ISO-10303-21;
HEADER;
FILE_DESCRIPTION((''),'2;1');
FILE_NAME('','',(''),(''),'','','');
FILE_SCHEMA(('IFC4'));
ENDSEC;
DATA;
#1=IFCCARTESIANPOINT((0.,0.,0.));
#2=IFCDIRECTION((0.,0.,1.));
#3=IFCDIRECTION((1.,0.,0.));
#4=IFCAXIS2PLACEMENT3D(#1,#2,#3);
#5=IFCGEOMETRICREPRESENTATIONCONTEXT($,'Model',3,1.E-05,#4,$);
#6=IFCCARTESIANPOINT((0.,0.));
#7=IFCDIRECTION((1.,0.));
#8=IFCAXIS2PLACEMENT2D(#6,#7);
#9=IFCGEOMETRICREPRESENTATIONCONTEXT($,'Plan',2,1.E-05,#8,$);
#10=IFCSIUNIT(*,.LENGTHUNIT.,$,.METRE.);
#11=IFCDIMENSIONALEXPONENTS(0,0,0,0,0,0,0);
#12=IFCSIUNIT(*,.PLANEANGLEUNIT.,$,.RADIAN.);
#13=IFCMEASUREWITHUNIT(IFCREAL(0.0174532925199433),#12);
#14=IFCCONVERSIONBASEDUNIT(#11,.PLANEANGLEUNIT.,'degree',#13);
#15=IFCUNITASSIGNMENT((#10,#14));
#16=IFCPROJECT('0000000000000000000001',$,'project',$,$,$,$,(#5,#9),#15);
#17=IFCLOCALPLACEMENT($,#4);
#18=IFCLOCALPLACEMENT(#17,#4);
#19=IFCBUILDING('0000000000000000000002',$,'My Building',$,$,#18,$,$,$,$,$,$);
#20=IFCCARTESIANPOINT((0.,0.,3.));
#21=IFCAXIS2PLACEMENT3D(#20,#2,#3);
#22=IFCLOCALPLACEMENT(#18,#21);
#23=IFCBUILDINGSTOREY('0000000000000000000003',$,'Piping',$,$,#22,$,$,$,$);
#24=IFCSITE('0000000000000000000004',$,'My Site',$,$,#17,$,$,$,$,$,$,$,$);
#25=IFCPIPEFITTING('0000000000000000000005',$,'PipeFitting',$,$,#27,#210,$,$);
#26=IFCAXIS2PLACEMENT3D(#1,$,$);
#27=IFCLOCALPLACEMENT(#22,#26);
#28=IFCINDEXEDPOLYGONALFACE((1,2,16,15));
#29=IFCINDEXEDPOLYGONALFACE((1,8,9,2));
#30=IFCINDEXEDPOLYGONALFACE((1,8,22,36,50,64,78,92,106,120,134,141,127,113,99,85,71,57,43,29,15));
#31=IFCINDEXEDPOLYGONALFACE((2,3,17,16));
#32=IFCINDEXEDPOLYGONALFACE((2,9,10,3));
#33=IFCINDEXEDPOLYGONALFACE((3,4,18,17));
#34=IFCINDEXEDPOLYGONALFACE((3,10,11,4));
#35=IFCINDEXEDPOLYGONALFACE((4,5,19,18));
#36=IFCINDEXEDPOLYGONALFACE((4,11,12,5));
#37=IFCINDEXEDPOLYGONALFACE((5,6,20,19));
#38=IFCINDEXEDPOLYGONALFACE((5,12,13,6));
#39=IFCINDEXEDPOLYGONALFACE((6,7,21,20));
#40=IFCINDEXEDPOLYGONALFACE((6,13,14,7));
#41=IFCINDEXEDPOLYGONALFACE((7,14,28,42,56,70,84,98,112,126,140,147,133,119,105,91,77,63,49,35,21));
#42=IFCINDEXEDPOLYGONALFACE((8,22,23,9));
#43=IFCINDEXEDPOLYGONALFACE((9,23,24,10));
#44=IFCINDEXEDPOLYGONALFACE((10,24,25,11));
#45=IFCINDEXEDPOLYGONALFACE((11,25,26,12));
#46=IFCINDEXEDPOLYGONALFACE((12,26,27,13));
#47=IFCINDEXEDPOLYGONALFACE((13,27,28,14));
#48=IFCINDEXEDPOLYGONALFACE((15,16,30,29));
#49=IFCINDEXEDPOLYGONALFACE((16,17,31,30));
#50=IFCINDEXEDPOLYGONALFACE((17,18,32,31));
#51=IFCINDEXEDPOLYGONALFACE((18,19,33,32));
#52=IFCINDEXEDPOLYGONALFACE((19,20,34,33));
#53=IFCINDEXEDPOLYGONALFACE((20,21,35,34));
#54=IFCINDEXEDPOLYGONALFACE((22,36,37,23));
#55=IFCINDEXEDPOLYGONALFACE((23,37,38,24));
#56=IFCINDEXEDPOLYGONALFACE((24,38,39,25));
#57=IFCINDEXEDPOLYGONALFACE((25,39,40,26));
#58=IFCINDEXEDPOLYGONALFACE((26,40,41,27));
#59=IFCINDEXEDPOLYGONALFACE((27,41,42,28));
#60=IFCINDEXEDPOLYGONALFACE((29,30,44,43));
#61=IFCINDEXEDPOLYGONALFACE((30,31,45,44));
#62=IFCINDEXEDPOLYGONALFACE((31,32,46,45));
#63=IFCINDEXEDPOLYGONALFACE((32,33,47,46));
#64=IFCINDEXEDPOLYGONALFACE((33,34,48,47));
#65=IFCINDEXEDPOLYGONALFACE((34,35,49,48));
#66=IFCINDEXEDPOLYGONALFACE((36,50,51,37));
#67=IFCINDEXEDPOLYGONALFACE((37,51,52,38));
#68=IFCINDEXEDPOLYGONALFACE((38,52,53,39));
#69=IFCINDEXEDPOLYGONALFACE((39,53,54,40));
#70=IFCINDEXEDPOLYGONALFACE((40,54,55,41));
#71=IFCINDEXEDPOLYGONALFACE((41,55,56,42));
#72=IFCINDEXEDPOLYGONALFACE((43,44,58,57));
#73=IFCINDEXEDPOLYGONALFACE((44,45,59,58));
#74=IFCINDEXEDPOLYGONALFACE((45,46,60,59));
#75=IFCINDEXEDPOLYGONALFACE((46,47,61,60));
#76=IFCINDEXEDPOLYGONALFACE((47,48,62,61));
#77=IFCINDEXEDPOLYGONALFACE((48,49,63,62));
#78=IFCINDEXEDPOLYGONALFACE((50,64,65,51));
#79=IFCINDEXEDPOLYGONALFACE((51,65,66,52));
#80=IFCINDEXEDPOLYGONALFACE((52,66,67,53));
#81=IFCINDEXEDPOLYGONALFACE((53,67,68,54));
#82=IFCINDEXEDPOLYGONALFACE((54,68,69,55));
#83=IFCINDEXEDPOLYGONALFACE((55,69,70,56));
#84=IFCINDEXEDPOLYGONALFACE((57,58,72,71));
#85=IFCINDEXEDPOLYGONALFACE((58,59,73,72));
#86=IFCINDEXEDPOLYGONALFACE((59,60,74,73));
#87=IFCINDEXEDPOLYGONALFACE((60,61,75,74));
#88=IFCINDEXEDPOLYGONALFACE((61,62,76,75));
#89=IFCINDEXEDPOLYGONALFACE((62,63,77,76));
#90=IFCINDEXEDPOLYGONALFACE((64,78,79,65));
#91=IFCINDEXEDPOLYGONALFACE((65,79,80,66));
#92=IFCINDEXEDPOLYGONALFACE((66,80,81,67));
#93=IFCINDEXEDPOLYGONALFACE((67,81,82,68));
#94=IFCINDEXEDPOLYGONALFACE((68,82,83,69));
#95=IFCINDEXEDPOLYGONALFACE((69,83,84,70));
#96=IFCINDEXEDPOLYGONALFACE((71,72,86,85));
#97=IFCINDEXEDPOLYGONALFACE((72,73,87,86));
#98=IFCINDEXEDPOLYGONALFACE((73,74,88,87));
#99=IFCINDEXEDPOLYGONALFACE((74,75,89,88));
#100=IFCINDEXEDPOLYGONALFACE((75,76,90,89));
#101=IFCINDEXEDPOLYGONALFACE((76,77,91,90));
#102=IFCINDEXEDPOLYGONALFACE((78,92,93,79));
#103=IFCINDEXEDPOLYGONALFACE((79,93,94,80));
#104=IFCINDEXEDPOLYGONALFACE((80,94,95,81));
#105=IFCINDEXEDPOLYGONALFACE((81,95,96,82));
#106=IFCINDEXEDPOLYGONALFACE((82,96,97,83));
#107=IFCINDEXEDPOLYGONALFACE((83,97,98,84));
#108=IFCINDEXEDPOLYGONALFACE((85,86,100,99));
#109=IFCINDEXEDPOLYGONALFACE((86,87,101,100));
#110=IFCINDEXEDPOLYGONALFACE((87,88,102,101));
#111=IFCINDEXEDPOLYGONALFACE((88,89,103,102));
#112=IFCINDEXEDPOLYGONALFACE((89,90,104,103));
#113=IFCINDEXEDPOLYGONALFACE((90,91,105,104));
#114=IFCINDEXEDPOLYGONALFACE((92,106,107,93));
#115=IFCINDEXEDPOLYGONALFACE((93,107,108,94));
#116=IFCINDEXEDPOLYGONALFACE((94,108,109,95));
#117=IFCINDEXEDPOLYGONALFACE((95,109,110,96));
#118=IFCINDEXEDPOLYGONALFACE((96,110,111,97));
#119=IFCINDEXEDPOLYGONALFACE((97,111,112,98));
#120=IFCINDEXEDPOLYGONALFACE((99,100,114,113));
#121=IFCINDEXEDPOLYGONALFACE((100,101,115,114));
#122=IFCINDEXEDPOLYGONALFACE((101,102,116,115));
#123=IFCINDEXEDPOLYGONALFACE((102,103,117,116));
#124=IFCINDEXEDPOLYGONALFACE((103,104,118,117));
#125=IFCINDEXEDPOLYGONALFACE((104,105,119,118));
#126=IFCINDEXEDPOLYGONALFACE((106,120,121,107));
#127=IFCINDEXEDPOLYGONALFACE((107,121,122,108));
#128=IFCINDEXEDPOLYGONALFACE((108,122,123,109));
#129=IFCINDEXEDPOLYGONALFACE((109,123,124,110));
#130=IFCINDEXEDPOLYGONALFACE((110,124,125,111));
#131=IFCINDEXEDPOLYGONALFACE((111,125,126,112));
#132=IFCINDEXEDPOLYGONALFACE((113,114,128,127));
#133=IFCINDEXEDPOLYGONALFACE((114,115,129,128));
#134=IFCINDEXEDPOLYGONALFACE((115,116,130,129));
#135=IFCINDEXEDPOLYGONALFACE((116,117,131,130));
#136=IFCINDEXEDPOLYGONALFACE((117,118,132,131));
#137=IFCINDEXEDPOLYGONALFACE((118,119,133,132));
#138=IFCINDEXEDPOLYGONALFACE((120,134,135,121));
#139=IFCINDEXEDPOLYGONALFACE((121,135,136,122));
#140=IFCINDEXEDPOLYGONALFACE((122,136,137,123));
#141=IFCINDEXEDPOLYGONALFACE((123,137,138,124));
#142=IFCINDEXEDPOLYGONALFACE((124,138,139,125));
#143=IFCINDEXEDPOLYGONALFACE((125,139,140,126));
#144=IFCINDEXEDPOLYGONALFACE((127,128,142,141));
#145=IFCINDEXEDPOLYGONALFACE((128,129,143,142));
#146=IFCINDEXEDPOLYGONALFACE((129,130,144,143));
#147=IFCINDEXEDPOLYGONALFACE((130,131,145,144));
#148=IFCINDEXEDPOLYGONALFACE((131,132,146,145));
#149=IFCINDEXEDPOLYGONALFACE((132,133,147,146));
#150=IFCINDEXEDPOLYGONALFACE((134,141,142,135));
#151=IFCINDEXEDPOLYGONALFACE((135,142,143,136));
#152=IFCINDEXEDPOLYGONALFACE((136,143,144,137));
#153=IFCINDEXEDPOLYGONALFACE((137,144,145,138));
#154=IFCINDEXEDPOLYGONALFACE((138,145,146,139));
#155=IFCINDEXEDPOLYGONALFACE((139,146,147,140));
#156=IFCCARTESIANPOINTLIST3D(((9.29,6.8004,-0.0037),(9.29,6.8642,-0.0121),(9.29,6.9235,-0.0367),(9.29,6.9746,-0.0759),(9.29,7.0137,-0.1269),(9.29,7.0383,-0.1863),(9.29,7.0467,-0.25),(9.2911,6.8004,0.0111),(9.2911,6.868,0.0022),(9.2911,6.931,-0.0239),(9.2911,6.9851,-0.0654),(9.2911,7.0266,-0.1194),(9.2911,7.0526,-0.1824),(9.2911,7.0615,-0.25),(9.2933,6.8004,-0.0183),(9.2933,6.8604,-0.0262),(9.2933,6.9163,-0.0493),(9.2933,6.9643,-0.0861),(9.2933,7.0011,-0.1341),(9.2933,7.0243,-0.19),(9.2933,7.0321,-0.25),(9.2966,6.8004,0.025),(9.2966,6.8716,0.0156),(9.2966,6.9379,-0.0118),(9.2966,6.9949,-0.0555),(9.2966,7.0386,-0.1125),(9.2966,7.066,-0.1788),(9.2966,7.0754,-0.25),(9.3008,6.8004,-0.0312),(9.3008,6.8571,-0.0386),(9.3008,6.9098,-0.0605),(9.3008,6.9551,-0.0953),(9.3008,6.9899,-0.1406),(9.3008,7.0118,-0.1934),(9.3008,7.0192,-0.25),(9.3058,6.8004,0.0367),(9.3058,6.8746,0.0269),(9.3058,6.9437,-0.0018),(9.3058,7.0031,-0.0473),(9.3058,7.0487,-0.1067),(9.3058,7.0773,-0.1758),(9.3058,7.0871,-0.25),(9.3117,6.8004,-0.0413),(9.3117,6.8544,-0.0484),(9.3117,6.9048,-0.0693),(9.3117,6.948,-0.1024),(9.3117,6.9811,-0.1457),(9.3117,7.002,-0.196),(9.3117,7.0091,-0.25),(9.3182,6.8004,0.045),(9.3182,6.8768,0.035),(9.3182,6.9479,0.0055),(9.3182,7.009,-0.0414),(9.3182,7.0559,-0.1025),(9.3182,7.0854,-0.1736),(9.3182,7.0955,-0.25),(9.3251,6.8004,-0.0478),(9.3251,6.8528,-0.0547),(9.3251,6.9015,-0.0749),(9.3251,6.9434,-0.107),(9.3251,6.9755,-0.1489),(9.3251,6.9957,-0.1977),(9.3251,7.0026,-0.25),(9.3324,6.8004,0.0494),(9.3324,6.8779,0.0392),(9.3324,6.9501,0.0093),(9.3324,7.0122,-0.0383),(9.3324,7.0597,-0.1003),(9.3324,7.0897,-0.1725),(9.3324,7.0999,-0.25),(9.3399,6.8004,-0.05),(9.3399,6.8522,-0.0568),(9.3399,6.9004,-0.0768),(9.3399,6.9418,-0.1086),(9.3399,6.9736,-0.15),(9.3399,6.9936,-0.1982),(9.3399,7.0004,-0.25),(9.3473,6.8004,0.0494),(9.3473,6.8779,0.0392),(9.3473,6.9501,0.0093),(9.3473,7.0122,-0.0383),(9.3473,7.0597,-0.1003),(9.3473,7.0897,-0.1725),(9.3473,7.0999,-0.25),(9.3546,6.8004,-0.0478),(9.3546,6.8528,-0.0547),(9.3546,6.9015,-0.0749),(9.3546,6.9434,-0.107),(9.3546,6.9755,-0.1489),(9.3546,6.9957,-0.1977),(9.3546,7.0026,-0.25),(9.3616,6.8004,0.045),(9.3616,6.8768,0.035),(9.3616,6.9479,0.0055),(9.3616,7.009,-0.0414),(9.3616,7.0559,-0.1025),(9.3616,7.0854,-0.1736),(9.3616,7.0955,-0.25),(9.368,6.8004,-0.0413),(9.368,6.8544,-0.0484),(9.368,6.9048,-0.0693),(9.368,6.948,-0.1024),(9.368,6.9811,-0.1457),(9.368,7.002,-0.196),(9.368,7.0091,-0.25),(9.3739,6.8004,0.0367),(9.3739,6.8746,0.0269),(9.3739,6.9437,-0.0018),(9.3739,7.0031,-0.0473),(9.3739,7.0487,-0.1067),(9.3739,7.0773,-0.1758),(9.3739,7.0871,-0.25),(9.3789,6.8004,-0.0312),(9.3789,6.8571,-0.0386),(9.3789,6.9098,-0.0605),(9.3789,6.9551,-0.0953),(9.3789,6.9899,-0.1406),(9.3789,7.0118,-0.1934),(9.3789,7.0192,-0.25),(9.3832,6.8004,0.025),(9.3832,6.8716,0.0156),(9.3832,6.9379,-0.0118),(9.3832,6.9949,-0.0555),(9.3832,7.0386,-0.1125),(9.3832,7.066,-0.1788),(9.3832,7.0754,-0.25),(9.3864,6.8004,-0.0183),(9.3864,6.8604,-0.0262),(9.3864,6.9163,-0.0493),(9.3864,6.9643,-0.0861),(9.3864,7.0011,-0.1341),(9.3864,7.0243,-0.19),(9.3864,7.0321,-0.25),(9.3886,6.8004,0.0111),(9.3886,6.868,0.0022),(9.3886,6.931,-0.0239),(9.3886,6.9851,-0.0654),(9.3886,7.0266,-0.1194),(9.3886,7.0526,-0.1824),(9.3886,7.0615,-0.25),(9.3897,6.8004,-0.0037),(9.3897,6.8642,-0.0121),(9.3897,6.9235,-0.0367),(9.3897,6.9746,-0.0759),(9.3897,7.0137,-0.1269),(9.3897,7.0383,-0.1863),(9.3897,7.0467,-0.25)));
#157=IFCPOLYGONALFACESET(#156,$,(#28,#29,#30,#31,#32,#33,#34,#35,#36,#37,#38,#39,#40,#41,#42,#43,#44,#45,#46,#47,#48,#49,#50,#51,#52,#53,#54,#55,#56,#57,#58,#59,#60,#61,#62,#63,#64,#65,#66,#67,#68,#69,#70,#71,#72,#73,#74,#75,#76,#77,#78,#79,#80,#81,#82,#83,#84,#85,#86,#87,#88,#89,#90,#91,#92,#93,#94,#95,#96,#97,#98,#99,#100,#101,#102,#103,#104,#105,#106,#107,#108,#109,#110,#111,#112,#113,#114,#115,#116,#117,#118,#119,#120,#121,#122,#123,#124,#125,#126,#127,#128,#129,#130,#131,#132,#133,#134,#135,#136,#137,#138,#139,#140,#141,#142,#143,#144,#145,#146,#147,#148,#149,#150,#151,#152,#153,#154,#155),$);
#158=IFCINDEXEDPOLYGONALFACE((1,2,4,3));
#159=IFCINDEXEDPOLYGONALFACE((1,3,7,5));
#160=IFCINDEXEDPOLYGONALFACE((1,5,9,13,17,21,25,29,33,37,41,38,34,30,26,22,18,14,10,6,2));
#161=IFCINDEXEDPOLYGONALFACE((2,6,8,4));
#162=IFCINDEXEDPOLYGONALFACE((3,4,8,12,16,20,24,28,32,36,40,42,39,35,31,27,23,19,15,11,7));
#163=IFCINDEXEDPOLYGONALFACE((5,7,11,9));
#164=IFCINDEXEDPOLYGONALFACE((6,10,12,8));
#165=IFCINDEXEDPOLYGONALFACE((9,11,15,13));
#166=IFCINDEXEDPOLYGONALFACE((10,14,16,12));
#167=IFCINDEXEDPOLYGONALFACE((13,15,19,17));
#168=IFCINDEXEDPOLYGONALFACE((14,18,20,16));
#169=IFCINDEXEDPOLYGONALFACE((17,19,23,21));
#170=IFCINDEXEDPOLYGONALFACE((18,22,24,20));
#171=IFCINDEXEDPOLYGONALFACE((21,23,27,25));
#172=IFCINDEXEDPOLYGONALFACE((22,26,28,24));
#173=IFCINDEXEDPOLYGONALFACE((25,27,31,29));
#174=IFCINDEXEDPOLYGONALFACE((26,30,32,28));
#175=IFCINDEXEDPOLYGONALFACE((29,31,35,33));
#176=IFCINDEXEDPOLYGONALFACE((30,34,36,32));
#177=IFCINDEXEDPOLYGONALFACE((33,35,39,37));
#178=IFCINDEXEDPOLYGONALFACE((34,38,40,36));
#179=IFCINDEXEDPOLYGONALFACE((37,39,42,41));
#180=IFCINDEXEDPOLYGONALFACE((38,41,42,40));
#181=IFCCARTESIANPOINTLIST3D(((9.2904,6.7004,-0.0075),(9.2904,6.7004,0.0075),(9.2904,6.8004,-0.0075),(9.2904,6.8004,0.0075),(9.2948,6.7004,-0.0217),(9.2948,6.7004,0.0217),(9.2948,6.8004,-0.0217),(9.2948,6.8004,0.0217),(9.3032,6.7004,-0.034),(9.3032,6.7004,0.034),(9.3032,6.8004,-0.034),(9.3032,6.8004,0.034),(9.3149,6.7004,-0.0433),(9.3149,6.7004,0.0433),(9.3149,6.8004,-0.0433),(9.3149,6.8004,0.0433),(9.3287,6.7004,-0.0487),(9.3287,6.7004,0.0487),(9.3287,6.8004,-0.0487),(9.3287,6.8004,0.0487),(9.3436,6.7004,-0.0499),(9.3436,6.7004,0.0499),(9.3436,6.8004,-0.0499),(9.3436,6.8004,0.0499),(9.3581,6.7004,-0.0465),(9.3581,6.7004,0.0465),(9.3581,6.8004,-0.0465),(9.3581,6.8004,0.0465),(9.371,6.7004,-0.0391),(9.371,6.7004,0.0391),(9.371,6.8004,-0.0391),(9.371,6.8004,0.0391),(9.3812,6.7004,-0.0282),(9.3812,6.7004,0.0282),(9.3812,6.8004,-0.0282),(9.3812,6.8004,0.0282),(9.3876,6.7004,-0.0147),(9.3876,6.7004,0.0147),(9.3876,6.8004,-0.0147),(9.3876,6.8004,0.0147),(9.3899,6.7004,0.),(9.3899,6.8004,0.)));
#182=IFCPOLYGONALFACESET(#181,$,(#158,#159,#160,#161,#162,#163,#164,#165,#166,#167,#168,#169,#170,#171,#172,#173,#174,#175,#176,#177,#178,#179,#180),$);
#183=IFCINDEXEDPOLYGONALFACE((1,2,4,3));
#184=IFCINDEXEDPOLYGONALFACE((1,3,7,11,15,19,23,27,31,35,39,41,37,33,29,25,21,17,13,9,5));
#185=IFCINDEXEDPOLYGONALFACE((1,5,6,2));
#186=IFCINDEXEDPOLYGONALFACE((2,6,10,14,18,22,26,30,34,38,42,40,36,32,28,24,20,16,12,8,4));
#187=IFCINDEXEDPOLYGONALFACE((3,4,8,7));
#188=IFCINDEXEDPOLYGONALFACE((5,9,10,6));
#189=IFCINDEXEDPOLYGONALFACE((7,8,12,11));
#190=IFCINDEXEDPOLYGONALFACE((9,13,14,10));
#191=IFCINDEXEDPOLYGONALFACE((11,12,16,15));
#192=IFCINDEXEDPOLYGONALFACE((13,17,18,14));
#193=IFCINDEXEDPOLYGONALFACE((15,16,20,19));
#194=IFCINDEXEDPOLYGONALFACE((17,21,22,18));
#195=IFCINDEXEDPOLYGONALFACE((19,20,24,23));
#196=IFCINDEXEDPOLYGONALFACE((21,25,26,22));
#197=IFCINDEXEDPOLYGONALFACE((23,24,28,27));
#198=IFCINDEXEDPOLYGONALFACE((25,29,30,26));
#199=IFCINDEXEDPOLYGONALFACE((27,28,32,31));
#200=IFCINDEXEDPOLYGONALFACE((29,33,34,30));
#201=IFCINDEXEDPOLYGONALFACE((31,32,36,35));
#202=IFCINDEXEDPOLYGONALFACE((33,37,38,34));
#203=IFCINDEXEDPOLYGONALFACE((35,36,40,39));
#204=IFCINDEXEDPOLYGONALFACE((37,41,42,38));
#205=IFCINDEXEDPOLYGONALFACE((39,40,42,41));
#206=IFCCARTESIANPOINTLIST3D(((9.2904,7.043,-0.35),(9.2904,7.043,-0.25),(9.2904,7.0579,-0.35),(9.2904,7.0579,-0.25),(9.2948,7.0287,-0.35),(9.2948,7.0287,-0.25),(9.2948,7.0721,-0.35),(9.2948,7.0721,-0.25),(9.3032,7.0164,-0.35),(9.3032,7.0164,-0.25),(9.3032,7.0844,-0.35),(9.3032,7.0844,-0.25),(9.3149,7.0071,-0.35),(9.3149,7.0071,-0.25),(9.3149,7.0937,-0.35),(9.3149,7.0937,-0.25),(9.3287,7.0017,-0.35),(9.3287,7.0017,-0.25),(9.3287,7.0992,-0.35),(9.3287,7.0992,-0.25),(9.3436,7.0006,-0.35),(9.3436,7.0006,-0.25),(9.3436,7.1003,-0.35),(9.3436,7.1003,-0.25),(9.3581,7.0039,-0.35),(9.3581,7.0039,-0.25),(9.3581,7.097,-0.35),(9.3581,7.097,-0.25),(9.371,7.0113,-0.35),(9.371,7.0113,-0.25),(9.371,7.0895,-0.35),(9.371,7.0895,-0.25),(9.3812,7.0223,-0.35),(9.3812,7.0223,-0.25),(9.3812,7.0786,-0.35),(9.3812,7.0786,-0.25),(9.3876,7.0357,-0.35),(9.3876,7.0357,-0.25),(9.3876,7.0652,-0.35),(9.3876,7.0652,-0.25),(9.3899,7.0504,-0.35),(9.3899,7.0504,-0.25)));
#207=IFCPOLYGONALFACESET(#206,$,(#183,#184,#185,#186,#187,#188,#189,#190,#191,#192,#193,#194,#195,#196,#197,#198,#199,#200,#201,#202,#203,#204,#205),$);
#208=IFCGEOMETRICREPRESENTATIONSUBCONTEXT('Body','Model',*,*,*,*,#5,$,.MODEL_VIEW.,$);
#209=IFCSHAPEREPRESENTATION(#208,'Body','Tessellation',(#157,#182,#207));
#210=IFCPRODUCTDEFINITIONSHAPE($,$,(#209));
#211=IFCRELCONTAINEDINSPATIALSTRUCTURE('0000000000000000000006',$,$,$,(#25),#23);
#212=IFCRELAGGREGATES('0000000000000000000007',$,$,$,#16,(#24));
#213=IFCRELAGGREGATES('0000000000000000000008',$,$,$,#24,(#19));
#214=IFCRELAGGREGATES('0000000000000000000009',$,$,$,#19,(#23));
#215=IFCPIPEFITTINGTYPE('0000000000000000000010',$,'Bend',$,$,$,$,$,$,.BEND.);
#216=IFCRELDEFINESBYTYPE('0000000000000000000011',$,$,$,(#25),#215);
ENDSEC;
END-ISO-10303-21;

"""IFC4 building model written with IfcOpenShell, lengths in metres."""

from ifc_helpers import new_model, entity, si_unit, converted_unit, frame, origin_with_axes, origin_2d_with_axis, place, context, subcontext, project, spatial, circle, extrude, source, transform, mapped, type_object, type_shapes, element, save


model = new_model("IFC4")

# Units and contexts
model_context = context("Model", 3, precision=1e-05, world=origin_with_axes())
plan_context = context("Plan", 2, precision=1e-05, world=origin_2d_with_axis())
body_context = subcontext(model_context, "Body", "Model", "MODEL_VIEW")
ifc_project = project(units=[si_unit("LENGTHUNIT", "METRE"), converted_unit("PLANEANGLEUNIT", "degree", entity("IfcReal", 0.0174532925199433), si_unit("PLANEANGLEUNIT", "RADIAN"), dimensions=[0, 0, 0, 0, 0, 0, 0])], contexts=[model_context, plan_context])

# Site, building, storey
site_placement = place(None, origin_with_axes())
site = spatial("IfcSite", under=ifc_project, at=site_placement, Name="My Site")
building_placement = place(site_placement, origin_with_axes())
building = spatial("IfcBuilding", under=site, at=building_placement, Name="My Building")
storey_placement = place(building_placement, frame((0.0, 0.0, 3.0), z_axis=(0.0, 0.0, 1.0), x_axis=(1.0, 0.0, 0.0)))
storey = spatial("IfcBuildingStorey", under=building, at=storey_placement, Name="Piping")

# Pipe fitting
pipe_fitting_type = type_object("IfcPipeFittingType", Name="Bend", PredefinedType="BEND")
shared_shape = source(origin_with_axes(), body_context, "Body", "SolidModel", [
    entity("IfcSweptDiskSolid", entity("IfcIndexedPolyCurve", entity("IfcCartesianPointList3D", [[0.0, 0.0, -0.1], [0.0, -0.0732, -0.2768], [0.0, -0.25, -0.35]]), [entity("IfcArcIndex", [1, 2, 3])]), 0.05),
    extrude(circle(Radius=0.05), origin_with_axes(), (0.0, 0.0, -1.0), 0.1),
    extrude(circle(Radius=0.05), frame((0.0, -0.25, -0.35), z_axis=(0.0, -1.0, 0.0), x_axis=(1.0, 0.0, 0.0)), (0.0, 0.0, 1.0), 0.1),
])
type_shapes(pipe_fitting_type, [shared_shape])
for number, where, z_axis, x_axis, name in (
    (1, (9.3399, 6.7004, 0.0), (0.0, -1.0, 0.0), (1.0, 0.0, 0.0), "PipeFitting"),
):
    element("IfcPipeFitting", number, at=place(storey_placement, frame(where, z_axis=z_axis, x_axis=x_axis)), inside=storey, type_object=pipe_fitting_type, Name=name, context=body_context, shape_type="MappedRepresentation", body=[
        mapped(shared_shape, transform((0.0, 0.0, 0.0), x_axis=(1.0, 0.0, 0.0), y_axis=(0.0, 1.0, 0.0), z_axis=(0.0, 0.0, 1.0), scale=1.0)),
    ])

save(model, "model.ifc")
